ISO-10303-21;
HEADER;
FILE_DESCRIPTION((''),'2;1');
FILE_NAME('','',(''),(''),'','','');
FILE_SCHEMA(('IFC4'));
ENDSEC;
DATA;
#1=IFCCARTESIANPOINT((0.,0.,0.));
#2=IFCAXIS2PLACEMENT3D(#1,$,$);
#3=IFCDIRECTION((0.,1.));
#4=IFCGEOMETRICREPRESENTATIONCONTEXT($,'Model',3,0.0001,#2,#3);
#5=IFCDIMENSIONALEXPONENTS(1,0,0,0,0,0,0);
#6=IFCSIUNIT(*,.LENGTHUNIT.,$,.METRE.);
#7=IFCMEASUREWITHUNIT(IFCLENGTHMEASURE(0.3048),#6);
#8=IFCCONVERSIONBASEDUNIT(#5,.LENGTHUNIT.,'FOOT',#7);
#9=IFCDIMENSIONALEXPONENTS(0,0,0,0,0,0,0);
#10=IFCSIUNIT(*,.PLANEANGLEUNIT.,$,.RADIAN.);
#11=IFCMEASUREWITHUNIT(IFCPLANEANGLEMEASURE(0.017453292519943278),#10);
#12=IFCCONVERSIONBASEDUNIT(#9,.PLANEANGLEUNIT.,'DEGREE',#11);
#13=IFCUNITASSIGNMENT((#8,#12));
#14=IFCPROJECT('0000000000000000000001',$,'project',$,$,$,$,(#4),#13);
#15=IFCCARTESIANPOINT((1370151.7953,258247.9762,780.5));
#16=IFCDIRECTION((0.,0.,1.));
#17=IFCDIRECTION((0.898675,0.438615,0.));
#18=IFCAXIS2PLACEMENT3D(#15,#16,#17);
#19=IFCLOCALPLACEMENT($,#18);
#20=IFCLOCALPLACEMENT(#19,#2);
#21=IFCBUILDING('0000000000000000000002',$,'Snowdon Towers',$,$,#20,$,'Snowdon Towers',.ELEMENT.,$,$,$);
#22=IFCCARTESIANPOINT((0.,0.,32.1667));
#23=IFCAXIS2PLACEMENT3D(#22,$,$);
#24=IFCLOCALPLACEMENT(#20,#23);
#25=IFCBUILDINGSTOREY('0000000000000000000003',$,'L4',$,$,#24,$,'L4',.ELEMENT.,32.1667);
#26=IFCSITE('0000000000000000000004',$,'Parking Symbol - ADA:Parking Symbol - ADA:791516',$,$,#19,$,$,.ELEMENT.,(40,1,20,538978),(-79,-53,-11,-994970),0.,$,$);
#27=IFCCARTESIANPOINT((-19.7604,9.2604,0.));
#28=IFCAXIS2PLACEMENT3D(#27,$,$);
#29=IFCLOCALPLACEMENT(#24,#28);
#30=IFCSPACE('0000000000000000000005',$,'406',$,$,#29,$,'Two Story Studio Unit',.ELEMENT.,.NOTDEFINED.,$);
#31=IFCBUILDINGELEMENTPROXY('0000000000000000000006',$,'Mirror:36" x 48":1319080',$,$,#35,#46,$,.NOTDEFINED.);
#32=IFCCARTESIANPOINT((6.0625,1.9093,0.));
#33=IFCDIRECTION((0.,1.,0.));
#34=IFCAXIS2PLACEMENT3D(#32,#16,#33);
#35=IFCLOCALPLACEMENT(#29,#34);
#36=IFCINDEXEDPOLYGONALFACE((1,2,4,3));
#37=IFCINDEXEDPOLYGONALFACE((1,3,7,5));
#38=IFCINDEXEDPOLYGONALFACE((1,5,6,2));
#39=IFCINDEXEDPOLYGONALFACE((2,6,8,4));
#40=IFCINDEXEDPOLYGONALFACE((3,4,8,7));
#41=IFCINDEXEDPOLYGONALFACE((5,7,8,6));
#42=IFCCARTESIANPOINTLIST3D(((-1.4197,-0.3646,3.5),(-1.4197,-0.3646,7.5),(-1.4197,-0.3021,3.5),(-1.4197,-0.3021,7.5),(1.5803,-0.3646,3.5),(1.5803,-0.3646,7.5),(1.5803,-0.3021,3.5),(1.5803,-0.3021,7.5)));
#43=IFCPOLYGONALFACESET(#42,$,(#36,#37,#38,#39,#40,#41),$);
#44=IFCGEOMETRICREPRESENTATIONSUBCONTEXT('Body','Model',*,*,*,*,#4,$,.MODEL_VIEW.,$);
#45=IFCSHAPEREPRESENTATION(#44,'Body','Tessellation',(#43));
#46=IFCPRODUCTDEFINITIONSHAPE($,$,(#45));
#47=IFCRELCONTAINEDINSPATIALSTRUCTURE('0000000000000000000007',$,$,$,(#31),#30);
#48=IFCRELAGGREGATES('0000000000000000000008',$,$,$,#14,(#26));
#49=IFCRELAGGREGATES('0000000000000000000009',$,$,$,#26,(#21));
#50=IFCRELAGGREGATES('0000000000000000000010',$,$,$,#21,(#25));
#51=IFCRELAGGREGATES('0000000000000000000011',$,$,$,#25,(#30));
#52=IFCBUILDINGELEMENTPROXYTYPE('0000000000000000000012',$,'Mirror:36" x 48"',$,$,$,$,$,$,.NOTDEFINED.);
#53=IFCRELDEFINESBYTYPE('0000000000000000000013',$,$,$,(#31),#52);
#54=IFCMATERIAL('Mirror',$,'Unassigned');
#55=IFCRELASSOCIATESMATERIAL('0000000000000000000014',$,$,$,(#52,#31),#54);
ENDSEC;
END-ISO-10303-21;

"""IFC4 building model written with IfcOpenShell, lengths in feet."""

from ifc_helpers import new_model, entity, si_unit, converted_unit, direction, frame, origin, place, context, subcontext, project, spatial, indexed_curve, outline, extrude, source, transform, mapped, material, type_object, type_shapes, element, save


model = new_model("IFC4")

# Units and contexts
model_context = context("Model", 3, precision=0.0001, world=origin(), true_north=direction((0.0, 1.0)))
body_context = subcontext(model_context, "Body", "Model", "MODEL_VIEW")
ifc_project = project(units=[converted_unit("LENGTHUNIT", "FOOT", entity("IfcLengthMeasure", 0.3048), si_unit("LENGTHUNIT", "METRE"), dimensions=[1, 0, 0, 0, 0, 0, 0]), converted_unit("PLANEANGLEUNIT", "DEGREE", entity("IfcPlaneAngleMeasure", 0.017453292519943278), si_unit("PLANEANGLEUNIT", "RADIAN"), dimensions=[0, 0, 0, 0, 0, 0, 0])], contexts=[model_context])

# Site, building, storey
site_placement = place(None, frame((1370151.7953, 258247.9762, 780.5), z_axis=(0.0, 0.0, 1.0), x_axis=(0.898675, 0.438615, 0.0)))
site = spatial("IfcSite", under=ifc_project, at=site_placement, Name="Parking Symbol - ADA:Parking Symbol - ADA:791516", CompositionType="ELEMENT", RefLatitude=(40, 1, 20, 538978), RefLongitude=(-79, -53, -11, -994970), RefElevation=0.0)
building_placement = place(site_placement, origin())
building = spatial("IfcBuilding", under=site, at=building_placement, Name="Snowdon Towers", LongName="Snowdon Towers", CompositionType="ELEMENT")
storey_placement = place(building_placement, frame((0.0, 0.0, 32.1667)))
storey = spatial("IfcBuildingStorey", under=building, at=storey_placement, Name="L4", LongName="L4", CompositionType="ELEMENT", Elevation=32.1667)

# Shared definitions
space_placement = place(storey_placement, frame((-19.7604, 9.2604, 0.0)))
space = spatial("IfcSpace", under=storey, at=space_placement, Name="406", LongName="Two Story Studio Unit", CompositionType="ELEMENT", PredefinedType="NOTDEFINED")

# Building element proxy
ifc_material_1 = material(Name="Mirror", Category="Unassigned")
building_element_proxy_type_1 = type_object("IfcBuildingElementProxyType", Name="Mirror:36\" x 48\"", PredefinedType="NOTDEFINED", material=ifc_material_1)
shared_shape_1 = source(origin(), body_context, "Body", "SweptSolid", [
    extrude(outline(indexed_curve([(-1.5, -0.0312), (1.5, -0.0312), (1.5, 0.0312), (-1.5, 0.0312), (-1.5, -0.0312)], self_intersect=False)), frame((0.0803, -0.3333, 3.5)), (0.0, 0.0, 1.0), 4.0),
])
type_shapes(building_element_proxy_type_1, [shared_shape_1])
proxy_1_placement = place(space_placement, frame((6.0625, 1.9093, 0.0), z_axis=(0.0, 0.0, 1.0), x_axis=(0.0, 1.0, 0.0)))
element("IfcBuildingElementProxy", 1, at=proxy_1_placement, inside=space, type_object=building_element_proxy_type_1, material=ifc_material_1, Name="Mirror:36\" x 48\":1319080", PredefinedType="NOTDEFINED", context=body_context, shape_type="MappedRepresentation", body=[
    mapped(shared_shape_1, transform((0.0, 0.0, 0.0), scale=1.0)),
])

save(model, "model.ifc")
